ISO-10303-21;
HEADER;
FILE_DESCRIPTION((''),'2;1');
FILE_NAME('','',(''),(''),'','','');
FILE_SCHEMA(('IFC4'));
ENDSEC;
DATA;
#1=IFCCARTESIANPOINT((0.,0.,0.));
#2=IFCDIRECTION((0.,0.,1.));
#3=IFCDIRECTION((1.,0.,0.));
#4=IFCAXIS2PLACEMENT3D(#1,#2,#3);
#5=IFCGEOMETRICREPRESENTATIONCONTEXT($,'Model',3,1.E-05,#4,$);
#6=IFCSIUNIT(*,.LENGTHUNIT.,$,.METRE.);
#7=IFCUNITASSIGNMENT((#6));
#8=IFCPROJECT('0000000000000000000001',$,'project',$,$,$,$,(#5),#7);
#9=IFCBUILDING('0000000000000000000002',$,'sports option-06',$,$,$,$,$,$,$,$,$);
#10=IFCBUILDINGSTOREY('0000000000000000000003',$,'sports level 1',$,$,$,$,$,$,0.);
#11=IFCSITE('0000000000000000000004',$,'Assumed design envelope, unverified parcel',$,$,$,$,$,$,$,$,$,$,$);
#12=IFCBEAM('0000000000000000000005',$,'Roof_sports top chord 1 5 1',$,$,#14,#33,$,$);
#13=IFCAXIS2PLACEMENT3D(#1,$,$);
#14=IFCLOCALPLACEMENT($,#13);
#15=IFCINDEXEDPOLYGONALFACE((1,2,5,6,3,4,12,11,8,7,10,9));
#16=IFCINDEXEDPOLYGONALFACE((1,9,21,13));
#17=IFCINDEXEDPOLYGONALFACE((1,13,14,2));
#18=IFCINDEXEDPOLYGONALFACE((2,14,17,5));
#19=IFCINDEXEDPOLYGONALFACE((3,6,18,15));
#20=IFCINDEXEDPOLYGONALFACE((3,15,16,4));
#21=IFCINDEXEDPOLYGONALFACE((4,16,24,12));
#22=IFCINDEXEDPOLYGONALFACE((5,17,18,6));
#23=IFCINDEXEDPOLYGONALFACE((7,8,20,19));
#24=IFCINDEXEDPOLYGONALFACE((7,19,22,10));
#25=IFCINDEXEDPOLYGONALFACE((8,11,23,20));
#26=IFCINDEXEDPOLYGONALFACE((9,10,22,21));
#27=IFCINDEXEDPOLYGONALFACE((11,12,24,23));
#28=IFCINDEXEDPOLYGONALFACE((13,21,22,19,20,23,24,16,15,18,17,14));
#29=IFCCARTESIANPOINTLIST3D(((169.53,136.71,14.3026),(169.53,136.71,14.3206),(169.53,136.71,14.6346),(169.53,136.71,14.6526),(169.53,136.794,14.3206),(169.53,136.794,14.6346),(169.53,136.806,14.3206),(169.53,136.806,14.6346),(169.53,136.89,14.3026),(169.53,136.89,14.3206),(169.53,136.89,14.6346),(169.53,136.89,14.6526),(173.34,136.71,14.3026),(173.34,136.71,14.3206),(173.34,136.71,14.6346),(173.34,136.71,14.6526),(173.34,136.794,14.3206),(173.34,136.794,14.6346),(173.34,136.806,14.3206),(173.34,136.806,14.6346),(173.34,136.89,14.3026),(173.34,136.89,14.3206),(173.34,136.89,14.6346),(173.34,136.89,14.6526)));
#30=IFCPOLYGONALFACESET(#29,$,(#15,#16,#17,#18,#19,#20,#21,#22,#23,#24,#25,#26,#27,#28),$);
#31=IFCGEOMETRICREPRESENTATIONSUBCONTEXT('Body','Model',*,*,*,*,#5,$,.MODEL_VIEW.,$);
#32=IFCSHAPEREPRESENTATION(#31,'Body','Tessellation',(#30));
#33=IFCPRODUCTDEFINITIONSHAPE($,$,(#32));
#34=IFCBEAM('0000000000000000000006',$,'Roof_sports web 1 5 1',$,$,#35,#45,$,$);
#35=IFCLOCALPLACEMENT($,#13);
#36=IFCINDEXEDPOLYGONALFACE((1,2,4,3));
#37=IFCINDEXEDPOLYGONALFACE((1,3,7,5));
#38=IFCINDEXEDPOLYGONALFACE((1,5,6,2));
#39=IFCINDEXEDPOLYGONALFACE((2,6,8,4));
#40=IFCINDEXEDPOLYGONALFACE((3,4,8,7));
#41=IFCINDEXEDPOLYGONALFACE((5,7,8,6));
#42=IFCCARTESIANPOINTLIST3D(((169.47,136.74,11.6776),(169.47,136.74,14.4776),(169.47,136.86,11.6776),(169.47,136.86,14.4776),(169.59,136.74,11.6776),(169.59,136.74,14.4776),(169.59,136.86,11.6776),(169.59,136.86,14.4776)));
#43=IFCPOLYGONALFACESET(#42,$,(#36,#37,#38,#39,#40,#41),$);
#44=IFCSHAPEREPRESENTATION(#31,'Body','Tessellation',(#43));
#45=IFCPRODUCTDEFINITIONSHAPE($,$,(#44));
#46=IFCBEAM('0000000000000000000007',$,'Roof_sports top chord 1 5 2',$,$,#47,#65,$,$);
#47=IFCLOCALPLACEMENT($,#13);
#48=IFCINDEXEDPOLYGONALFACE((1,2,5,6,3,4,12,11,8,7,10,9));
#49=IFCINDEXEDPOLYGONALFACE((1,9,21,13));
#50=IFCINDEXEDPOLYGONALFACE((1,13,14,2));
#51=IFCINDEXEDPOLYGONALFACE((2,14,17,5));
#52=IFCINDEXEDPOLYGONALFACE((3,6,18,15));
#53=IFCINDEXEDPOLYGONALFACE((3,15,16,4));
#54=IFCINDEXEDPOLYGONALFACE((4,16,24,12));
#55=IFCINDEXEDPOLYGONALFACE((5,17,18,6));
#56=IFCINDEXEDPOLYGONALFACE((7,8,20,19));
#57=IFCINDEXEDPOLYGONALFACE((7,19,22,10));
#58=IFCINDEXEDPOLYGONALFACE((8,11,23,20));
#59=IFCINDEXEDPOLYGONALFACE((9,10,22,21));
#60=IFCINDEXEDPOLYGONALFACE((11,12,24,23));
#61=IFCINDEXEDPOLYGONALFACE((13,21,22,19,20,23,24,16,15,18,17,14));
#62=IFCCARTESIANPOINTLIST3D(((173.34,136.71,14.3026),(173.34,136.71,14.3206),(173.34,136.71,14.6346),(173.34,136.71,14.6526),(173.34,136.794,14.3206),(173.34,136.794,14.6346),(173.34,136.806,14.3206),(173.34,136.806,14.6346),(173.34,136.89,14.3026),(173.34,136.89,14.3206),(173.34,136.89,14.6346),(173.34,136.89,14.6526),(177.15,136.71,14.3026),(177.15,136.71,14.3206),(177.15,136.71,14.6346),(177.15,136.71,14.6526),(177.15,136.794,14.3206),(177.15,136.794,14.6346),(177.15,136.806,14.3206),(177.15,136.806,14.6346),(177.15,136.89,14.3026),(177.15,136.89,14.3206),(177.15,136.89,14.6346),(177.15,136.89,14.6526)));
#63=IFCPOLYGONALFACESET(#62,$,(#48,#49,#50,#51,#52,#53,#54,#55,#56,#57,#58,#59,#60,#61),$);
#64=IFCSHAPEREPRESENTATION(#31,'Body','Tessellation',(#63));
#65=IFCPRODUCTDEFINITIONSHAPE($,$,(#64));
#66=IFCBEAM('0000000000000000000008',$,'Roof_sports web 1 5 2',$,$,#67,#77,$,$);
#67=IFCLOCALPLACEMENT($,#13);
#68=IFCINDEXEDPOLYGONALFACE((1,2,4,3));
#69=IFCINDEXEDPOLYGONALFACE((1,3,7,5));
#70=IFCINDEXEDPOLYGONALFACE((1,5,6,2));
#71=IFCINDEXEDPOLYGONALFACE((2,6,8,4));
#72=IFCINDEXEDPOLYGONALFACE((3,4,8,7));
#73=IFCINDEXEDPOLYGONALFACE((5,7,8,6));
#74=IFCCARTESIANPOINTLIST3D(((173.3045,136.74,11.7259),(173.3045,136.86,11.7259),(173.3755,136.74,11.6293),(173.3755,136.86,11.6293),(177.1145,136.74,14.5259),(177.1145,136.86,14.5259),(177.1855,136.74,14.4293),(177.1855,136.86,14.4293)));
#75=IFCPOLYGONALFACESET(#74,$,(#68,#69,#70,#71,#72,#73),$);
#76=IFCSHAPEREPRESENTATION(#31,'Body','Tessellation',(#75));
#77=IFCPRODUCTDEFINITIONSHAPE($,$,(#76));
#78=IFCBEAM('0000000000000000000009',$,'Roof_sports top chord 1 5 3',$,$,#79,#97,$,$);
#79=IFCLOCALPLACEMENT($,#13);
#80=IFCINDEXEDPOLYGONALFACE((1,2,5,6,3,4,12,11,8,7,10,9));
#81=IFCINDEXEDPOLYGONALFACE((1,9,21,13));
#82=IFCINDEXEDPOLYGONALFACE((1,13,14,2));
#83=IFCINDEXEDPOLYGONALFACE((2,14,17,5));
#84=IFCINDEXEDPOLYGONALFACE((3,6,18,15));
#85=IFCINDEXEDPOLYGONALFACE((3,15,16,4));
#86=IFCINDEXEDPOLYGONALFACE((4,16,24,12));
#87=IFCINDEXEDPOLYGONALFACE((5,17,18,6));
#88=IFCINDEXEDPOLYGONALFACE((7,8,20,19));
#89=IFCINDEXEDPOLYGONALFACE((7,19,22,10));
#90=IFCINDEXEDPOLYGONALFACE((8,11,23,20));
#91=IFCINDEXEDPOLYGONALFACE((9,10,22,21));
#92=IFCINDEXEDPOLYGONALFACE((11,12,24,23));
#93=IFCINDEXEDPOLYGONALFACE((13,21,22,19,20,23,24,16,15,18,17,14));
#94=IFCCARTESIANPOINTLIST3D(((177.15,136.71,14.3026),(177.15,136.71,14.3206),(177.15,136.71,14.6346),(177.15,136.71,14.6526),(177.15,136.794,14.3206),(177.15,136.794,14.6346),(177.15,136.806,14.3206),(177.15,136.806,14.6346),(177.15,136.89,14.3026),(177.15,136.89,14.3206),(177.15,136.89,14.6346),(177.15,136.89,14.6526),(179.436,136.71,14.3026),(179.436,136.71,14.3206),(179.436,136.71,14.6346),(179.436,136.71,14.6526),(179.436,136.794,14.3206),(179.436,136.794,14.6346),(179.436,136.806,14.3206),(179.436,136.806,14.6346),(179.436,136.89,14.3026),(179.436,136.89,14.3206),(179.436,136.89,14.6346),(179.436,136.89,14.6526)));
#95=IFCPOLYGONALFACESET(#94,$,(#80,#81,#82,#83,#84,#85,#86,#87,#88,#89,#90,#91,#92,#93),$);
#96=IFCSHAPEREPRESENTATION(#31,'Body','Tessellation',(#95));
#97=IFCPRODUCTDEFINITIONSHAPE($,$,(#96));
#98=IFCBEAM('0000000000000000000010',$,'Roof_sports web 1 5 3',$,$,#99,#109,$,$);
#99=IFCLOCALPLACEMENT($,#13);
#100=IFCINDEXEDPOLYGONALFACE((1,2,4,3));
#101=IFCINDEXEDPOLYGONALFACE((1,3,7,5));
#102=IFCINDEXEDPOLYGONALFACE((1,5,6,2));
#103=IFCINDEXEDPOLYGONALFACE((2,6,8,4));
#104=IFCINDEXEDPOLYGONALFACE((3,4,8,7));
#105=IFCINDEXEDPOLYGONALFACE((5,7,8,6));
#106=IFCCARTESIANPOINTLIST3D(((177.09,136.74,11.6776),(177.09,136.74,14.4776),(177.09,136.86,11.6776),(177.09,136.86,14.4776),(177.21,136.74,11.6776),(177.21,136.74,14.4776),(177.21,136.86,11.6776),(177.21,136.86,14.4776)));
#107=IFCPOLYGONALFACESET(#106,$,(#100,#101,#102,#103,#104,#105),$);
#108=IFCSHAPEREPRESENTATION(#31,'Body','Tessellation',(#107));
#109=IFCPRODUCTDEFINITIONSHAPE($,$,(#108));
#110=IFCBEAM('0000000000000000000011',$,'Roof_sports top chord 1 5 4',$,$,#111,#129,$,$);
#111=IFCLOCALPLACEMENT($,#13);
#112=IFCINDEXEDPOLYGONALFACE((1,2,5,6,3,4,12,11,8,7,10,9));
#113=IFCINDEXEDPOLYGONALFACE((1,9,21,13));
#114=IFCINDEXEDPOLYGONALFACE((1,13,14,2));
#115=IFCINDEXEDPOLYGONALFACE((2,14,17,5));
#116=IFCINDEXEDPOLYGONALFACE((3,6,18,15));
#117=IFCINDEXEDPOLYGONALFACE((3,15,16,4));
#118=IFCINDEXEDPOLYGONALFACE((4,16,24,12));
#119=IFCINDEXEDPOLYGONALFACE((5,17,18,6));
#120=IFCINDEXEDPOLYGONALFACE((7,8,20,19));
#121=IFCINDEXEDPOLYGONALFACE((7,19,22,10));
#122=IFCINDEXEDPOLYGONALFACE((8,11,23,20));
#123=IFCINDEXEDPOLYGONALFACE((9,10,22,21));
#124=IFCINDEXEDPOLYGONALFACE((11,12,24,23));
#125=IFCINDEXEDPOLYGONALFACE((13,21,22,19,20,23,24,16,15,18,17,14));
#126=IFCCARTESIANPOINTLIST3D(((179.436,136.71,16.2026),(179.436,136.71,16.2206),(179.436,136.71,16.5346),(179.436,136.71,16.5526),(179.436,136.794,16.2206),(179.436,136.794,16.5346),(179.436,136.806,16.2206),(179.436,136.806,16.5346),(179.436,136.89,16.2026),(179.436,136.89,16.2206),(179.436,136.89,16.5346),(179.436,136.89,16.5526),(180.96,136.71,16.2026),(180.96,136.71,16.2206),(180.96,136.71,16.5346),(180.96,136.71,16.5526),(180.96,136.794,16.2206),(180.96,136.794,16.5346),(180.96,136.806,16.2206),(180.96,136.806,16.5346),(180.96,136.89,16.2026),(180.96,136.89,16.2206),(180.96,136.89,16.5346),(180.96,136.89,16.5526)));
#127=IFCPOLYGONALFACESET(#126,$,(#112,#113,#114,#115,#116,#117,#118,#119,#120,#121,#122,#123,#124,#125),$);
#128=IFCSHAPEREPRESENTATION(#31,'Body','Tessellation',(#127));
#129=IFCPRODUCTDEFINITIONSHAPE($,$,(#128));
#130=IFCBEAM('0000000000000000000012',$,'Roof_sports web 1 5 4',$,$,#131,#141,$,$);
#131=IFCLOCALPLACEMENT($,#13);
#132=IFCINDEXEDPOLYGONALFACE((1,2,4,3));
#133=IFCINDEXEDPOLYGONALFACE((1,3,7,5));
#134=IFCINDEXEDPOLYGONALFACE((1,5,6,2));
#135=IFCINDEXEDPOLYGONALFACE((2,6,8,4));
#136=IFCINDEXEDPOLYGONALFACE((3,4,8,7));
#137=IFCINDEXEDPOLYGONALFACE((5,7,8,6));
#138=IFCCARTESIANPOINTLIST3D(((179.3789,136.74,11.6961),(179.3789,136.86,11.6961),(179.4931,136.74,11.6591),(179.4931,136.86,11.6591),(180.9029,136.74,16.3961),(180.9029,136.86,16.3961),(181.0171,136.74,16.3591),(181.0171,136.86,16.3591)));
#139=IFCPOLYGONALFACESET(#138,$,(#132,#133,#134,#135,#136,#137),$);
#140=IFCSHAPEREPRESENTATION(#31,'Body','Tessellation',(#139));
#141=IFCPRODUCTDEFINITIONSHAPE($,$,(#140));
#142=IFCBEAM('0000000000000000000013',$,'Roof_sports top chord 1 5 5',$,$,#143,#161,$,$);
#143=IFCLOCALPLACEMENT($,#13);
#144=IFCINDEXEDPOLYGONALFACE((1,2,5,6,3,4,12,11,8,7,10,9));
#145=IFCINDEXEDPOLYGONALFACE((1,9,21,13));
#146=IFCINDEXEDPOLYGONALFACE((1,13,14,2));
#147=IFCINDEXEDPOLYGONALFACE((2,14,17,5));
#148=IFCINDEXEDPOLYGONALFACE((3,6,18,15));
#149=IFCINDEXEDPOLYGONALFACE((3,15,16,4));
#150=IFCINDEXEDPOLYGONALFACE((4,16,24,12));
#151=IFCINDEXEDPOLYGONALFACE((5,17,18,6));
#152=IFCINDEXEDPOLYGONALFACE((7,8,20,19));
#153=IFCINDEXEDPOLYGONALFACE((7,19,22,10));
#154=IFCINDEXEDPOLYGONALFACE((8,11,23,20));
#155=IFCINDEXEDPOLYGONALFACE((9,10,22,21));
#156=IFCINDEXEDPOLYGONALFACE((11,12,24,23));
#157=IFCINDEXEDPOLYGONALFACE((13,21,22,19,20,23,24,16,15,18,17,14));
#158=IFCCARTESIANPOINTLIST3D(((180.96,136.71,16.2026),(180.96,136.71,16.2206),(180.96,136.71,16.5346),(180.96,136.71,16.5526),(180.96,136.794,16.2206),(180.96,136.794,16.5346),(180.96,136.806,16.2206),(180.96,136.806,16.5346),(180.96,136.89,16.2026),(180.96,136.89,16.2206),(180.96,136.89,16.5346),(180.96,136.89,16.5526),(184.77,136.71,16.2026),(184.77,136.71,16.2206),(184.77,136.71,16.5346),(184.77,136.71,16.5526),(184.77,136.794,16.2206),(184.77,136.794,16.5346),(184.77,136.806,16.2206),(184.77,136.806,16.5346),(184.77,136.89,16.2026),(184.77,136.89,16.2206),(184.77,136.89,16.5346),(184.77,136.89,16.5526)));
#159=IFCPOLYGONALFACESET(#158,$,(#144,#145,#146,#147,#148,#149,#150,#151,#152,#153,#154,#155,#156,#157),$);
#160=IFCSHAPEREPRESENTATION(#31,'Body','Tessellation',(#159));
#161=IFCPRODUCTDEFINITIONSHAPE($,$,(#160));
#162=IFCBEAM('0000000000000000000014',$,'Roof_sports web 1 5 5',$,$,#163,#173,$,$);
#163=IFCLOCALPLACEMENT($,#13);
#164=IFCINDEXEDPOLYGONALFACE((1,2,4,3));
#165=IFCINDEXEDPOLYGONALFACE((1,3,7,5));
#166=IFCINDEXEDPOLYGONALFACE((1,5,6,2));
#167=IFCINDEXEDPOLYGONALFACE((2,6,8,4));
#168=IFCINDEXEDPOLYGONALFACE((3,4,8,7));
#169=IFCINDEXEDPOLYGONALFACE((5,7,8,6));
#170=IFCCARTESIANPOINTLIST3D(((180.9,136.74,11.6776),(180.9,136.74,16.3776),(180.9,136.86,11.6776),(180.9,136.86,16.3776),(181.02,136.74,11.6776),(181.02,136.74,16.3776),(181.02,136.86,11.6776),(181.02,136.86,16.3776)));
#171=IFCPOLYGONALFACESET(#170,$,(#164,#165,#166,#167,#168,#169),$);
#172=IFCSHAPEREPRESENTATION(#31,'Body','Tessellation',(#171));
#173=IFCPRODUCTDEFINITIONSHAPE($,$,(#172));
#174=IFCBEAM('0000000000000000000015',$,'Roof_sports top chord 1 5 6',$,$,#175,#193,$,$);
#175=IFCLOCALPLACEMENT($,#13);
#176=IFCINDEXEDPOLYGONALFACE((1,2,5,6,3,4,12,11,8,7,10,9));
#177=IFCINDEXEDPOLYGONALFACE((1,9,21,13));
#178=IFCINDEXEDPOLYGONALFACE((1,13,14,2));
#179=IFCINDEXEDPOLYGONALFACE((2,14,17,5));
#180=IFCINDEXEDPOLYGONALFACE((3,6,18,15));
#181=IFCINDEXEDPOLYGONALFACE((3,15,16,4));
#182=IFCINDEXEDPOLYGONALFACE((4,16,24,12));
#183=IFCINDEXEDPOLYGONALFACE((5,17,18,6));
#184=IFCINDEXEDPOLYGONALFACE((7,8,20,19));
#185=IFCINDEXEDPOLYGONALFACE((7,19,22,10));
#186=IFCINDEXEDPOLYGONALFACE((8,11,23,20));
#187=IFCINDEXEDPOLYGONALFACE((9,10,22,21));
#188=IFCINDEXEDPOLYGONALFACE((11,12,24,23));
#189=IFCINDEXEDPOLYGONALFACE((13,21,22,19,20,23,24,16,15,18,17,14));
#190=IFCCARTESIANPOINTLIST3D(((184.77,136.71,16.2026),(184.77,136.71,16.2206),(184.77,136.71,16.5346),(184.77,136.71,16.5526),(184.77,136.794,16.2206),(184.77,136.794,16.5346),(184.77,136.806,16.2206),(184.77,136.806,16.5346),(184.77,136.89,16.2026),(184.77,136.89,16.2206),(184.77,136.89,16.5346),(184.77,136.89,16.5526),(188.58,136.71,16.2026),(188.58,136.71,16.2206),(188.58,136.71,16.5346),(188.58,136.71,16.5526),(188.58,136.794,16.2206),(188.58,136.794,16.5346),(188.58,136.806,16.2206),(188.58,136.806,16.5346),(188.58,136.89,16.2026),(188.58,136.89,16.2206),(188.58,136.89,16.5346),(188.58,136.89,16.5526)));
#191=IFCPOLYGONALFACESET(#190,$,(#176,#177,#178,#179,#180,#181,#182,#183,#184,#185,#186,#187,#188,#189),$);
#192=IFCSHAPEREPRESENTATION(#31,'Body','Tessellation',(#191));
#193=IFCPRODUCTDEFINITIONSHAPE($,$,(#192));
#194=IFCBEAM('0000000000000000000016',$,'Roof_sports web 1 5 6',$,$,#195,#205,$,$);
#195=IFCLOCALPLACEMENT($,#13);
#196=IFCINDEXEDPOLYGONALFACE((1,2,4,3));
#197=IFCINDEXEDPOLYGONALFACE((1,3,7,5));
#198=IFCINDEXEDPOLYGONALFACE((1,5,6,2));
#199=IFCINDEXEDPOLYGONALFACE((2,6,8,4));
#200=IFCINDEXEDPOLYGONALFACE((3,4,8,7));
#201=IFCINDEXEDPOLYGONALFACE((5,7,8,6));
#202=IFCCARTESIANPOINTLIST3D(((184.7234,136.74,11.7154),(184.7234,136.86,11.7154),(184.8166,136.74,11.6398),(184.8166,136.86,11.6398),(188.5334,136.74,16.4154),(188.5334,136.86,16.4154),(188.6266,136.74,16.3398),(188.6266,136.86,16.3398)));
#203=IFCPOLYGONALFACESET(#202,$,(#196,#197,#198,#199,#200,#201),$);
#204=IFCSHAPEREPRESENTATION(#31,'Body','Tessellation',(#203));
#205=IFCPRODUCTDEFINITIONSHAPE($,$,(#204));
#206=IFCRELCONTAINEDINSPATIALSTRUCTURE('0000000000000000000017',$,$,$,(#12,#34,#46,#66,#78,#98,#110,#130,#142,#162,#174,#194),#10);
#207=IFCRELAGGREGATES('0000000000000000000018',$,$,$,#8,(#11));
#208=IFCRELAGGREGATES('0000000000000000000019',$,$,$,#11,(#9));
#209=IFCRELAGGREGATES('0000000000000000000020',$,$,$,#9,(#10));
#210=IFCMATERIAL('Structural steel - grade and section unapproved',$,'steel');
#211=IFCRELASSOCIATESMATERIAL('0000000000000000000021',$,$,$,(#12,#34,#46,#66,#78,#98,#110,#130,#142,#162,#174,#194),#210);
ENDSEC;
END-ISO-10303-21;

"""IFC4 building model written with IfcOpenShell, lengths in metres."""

from ifc_helpers import new_model, si_unit, frame, origin_with_axes, place, context, subcontext, project, spatial, rectangle, i_section, extrude, material, element, save


model = new_model("IFC4")

# Units and contexts
model_context = context("Model", 3, precision=1e-05, world=origin_with_axes())
body_context = subcontext(model_context, "Body", "Model", "MODEL_VIEW")
ifc_project = project(units=[si_unit("LENGTHUNIT", "METRE")], contexts=[model_context])

# Site, building, storey
site = spatial("IfcSite", under=ifc_project, Name="Assumed design envelope, unverified parcel")
building = spatial("IfcBuilding", under=site, Name="sports option-06")
storey = spatial("IfcBuildingStorey", under=building, Name="sports level 1", Elevation=0.0)

# Beams
ifc_material_1 = material(Name="Structural steel - grade and section unapproved", Category="steel")
beam_1_placement = place(None, frame((169.53, 136.8, 14.4776), z_axis=(1.0, 0.0, 0.0), x_axis=(0.0, 1.0, 0.0)))
element("IfcBeam", 1, at=beam_1_placement, inside=storey, material=ifc_material_1, Name="Roof_sports top chord 1 5 1", context=body_context, shape_type="SweptSolid", body=[
    extrude(i_section(OverallWidth=0.18, OverallDepth=0.35, WebThickness=0.012, FlangeThickness=0.018, FilletRadius=0.0), origin_with_axes(), (0.0, 0.0, 1.0), 3.81),
])
beam_2_placement = place(None, frame((169.53, 136.8, 11.6776), z_axis=(0.0, 0.0, 1.0), x_axis=(-1.0, 0.0, 0.0)))
element("IfcBeam", 2, at=beam_2_placement, inside=storey, material=ifc_material_1, Name="Roof_sports web 1 5 1", context=body_context, shape_type="SweptSolid", body=[
    extrude(rectangle(XDim=0.12, YDim=0.12), origin_with_axes(), (0.0, 0.0, 1.0), 2.8),
])
beam_3_placement = place(None, frame((173.34, 136.8, 14.4776), z_axis=(1.0, 0.0, 0.0), x_axis=(0.0, 1.0, 0.0)))
element("IfcBeam", 3, at=beam_3_placement, inside=storey, material=ifc_material_1, Name="Roof_sports top chord 1 5 2", context=body_context, shape_type="SweptSolid", body=[
    extrude(i_section(OverallWidth=0.18, OverallDepth=0.35, WebThickness=0.012, FlangeThickness=0.018, FilletRadius=0.0), origin_with_axes(), (0.0, 0.0, 1.0), 3.81),
])
beam_4_placement = place(None, frame((173.34, 136.8, 11.6776), z_axis=(0.805799, 0.0, 0.592189), x_axis=(0.0, 1.0, 0.0)))
element("IfcBeam", 4, at=beam_4_placement, inside=storey, material=ifc_material_1, Name="Roof_sports web 1 5 2", context=body_context, shape_type="SweptSolid", body=[
    extrude(rectangle(XDim=0.12, YDim=0.12), origin_with_axes(), (0.0, 0.0, 1.0), 4.7282),
])
beam_5_placement = place(None, frame((177.15, 136.8, 14.4776), z_axis=(1.0, 0.0, 0.0), x_axis=(0.0, 1.0, 0.0)))
element("IfcBeam", 5, at=beam_5_placement, inside=storey, material=ifc_material_1, Name="Roof_sports top chord 1 5 3", context=body_context, shape_type="SweptSolid", body=[
    extrude(i_section(OverallWidth=0.18, OverallDepth=0.35, WebThickness=0.012, FlangeThickness=0.018, FilletRadius=0.0), origin_with_axes(), (0.0, 0.0, 1.0), 2.286),
])
beam_6_placement = place(None, frame((177.15, 136.8, 11.6776), z_axis=(0.0, 0.0, 1.0), x_axis=(-1.0, 0.0, 0.0)))
element("IfcBeam", 6, at=beam_6_placement, inside=storey, material=ifc_material_1, Name="Roof_sports web 1 5 3", context=body_context, shape_type="SweptSolid", body=[
    extrude(rectangle(XDim=0.12, YDim=0.12), origin_with_axes(), (0.0, 0.0, 1.0), 2.8),
])
beam_7_placement = place(None, frame((179.436, 136.8, 16.3776), z_axis=(1.0, 0.0, 0.0), x_axis=(0.0, 1.0, 0.0)))
element("IfcBeam", 7, at=beam_7_placement, inside=storey, material=ifc_material_1, Name="Roof_sports top chord 1 5 4", context=body_context, shape_type="SweptSolid", body=[
    extrude(i_section(OverallWidth=0.18, OverallDepth=0.35, WebThickness=0.012, FlangeThickness=0.018, FilletRadius=0.0), origin_with_axes(), (0.0, 0.0, 1.0), 1.524),
])
beam_8_placement = place(None, frame((179.436, 136.8, 11.6776), z_axis=(0.308446, 0.0, 0.951242), x_axis=(0.0, 1.0, 0.0)))
element("IfcBeam", 8, at=beam_8_placement, inside=storey, material=ifc_material_1, Name="Roof_sports web 1 5 4", context=body_context, shape_type="SweptSolid", body=[
    extrude(rectangle(XDim=0.12, YDim=0.12), origin_with_axes(), (0.0, 0.0, 1.0), 4.9409),
])
beam_9_placement = place(None, frame((180.96, 136.8, 16.3776), z_axis=(1.0, 0.0, 0.0), x_axis=(0.0, 1.0, 0.0)))
element("IfcBeam", 9, at=beam_9_placement, inside=storey, material=ifc_material_1, Name="Roof_sports top chord 1 5 5", context=body_context, shape_type="SweptSolid", body=[
    extrude(i_section(OverallWidth=0.18, OverallDepth=0.35, WebThickness=0.012, FlangeThickness=0.018, FilletRadius=0.0), origin_with_axes(), (0.0, 0.0, 1.0), 3.81),
])
beam_10_placement = place(None, frame((180.96, 136.8, 11.6776), z_axis=(0.0, 0.0, 1.0), x_axis=(-1.0, 0.0, 0.0)))
element("IfcBeam", 10, at=beam_10_placement, inside=storey, material=ifc_material_1, Name="Roof_sports web 1 5 5", context=body_context, shape_type="SweptSolid", body=[
    extrude(rectangle(XDim=0.12, YDim=0.12), origin_with_axes(), (0.0, 0.0, 1.0), 4.7),
])
beam_11_placement = place(None, frame((184.77, 136.8, 16.3776), z_axis=(1.0, 0.0, 0.0), x_axis=(0.0, 1.0, 0.0)))
element("IfcBeam", 11, at=beam_11_placement, inside=storey, material=ifc_material_1, Name="Roof_sports top chord 1 5 6", context=body_context, shape_type="SweptSolid", body=[
    extrude(i_section(OverallWidth=0.18, OverallDepth=0.35, WebThickness=0.012, FlangeThickness=0.018, FilletRadius=0.0), origin_with_axes(), (0.0, 0.0, 1.0), 3.81),
])
beam_12_placement = place(None, frame((184.77, 136.8, 11.6776), z_axis=(0.629721, 0.0, 0.776821), x_axis=(0.0, 1.0, 0.0)))
element("IfcBeam", 12, at=beam_12_placement, inside=storey, material=ifc_material_1, Name="Roof_sports web 1 5 6", context=body_context, shape_type="SweptSolid", body=[
    extrude(rectangle(XDim=0.12, YDim=0.12), origin_with_axes(), (0.0, 0.0, 1.0), 6.0503),
])

save(model, "model.ifc")
